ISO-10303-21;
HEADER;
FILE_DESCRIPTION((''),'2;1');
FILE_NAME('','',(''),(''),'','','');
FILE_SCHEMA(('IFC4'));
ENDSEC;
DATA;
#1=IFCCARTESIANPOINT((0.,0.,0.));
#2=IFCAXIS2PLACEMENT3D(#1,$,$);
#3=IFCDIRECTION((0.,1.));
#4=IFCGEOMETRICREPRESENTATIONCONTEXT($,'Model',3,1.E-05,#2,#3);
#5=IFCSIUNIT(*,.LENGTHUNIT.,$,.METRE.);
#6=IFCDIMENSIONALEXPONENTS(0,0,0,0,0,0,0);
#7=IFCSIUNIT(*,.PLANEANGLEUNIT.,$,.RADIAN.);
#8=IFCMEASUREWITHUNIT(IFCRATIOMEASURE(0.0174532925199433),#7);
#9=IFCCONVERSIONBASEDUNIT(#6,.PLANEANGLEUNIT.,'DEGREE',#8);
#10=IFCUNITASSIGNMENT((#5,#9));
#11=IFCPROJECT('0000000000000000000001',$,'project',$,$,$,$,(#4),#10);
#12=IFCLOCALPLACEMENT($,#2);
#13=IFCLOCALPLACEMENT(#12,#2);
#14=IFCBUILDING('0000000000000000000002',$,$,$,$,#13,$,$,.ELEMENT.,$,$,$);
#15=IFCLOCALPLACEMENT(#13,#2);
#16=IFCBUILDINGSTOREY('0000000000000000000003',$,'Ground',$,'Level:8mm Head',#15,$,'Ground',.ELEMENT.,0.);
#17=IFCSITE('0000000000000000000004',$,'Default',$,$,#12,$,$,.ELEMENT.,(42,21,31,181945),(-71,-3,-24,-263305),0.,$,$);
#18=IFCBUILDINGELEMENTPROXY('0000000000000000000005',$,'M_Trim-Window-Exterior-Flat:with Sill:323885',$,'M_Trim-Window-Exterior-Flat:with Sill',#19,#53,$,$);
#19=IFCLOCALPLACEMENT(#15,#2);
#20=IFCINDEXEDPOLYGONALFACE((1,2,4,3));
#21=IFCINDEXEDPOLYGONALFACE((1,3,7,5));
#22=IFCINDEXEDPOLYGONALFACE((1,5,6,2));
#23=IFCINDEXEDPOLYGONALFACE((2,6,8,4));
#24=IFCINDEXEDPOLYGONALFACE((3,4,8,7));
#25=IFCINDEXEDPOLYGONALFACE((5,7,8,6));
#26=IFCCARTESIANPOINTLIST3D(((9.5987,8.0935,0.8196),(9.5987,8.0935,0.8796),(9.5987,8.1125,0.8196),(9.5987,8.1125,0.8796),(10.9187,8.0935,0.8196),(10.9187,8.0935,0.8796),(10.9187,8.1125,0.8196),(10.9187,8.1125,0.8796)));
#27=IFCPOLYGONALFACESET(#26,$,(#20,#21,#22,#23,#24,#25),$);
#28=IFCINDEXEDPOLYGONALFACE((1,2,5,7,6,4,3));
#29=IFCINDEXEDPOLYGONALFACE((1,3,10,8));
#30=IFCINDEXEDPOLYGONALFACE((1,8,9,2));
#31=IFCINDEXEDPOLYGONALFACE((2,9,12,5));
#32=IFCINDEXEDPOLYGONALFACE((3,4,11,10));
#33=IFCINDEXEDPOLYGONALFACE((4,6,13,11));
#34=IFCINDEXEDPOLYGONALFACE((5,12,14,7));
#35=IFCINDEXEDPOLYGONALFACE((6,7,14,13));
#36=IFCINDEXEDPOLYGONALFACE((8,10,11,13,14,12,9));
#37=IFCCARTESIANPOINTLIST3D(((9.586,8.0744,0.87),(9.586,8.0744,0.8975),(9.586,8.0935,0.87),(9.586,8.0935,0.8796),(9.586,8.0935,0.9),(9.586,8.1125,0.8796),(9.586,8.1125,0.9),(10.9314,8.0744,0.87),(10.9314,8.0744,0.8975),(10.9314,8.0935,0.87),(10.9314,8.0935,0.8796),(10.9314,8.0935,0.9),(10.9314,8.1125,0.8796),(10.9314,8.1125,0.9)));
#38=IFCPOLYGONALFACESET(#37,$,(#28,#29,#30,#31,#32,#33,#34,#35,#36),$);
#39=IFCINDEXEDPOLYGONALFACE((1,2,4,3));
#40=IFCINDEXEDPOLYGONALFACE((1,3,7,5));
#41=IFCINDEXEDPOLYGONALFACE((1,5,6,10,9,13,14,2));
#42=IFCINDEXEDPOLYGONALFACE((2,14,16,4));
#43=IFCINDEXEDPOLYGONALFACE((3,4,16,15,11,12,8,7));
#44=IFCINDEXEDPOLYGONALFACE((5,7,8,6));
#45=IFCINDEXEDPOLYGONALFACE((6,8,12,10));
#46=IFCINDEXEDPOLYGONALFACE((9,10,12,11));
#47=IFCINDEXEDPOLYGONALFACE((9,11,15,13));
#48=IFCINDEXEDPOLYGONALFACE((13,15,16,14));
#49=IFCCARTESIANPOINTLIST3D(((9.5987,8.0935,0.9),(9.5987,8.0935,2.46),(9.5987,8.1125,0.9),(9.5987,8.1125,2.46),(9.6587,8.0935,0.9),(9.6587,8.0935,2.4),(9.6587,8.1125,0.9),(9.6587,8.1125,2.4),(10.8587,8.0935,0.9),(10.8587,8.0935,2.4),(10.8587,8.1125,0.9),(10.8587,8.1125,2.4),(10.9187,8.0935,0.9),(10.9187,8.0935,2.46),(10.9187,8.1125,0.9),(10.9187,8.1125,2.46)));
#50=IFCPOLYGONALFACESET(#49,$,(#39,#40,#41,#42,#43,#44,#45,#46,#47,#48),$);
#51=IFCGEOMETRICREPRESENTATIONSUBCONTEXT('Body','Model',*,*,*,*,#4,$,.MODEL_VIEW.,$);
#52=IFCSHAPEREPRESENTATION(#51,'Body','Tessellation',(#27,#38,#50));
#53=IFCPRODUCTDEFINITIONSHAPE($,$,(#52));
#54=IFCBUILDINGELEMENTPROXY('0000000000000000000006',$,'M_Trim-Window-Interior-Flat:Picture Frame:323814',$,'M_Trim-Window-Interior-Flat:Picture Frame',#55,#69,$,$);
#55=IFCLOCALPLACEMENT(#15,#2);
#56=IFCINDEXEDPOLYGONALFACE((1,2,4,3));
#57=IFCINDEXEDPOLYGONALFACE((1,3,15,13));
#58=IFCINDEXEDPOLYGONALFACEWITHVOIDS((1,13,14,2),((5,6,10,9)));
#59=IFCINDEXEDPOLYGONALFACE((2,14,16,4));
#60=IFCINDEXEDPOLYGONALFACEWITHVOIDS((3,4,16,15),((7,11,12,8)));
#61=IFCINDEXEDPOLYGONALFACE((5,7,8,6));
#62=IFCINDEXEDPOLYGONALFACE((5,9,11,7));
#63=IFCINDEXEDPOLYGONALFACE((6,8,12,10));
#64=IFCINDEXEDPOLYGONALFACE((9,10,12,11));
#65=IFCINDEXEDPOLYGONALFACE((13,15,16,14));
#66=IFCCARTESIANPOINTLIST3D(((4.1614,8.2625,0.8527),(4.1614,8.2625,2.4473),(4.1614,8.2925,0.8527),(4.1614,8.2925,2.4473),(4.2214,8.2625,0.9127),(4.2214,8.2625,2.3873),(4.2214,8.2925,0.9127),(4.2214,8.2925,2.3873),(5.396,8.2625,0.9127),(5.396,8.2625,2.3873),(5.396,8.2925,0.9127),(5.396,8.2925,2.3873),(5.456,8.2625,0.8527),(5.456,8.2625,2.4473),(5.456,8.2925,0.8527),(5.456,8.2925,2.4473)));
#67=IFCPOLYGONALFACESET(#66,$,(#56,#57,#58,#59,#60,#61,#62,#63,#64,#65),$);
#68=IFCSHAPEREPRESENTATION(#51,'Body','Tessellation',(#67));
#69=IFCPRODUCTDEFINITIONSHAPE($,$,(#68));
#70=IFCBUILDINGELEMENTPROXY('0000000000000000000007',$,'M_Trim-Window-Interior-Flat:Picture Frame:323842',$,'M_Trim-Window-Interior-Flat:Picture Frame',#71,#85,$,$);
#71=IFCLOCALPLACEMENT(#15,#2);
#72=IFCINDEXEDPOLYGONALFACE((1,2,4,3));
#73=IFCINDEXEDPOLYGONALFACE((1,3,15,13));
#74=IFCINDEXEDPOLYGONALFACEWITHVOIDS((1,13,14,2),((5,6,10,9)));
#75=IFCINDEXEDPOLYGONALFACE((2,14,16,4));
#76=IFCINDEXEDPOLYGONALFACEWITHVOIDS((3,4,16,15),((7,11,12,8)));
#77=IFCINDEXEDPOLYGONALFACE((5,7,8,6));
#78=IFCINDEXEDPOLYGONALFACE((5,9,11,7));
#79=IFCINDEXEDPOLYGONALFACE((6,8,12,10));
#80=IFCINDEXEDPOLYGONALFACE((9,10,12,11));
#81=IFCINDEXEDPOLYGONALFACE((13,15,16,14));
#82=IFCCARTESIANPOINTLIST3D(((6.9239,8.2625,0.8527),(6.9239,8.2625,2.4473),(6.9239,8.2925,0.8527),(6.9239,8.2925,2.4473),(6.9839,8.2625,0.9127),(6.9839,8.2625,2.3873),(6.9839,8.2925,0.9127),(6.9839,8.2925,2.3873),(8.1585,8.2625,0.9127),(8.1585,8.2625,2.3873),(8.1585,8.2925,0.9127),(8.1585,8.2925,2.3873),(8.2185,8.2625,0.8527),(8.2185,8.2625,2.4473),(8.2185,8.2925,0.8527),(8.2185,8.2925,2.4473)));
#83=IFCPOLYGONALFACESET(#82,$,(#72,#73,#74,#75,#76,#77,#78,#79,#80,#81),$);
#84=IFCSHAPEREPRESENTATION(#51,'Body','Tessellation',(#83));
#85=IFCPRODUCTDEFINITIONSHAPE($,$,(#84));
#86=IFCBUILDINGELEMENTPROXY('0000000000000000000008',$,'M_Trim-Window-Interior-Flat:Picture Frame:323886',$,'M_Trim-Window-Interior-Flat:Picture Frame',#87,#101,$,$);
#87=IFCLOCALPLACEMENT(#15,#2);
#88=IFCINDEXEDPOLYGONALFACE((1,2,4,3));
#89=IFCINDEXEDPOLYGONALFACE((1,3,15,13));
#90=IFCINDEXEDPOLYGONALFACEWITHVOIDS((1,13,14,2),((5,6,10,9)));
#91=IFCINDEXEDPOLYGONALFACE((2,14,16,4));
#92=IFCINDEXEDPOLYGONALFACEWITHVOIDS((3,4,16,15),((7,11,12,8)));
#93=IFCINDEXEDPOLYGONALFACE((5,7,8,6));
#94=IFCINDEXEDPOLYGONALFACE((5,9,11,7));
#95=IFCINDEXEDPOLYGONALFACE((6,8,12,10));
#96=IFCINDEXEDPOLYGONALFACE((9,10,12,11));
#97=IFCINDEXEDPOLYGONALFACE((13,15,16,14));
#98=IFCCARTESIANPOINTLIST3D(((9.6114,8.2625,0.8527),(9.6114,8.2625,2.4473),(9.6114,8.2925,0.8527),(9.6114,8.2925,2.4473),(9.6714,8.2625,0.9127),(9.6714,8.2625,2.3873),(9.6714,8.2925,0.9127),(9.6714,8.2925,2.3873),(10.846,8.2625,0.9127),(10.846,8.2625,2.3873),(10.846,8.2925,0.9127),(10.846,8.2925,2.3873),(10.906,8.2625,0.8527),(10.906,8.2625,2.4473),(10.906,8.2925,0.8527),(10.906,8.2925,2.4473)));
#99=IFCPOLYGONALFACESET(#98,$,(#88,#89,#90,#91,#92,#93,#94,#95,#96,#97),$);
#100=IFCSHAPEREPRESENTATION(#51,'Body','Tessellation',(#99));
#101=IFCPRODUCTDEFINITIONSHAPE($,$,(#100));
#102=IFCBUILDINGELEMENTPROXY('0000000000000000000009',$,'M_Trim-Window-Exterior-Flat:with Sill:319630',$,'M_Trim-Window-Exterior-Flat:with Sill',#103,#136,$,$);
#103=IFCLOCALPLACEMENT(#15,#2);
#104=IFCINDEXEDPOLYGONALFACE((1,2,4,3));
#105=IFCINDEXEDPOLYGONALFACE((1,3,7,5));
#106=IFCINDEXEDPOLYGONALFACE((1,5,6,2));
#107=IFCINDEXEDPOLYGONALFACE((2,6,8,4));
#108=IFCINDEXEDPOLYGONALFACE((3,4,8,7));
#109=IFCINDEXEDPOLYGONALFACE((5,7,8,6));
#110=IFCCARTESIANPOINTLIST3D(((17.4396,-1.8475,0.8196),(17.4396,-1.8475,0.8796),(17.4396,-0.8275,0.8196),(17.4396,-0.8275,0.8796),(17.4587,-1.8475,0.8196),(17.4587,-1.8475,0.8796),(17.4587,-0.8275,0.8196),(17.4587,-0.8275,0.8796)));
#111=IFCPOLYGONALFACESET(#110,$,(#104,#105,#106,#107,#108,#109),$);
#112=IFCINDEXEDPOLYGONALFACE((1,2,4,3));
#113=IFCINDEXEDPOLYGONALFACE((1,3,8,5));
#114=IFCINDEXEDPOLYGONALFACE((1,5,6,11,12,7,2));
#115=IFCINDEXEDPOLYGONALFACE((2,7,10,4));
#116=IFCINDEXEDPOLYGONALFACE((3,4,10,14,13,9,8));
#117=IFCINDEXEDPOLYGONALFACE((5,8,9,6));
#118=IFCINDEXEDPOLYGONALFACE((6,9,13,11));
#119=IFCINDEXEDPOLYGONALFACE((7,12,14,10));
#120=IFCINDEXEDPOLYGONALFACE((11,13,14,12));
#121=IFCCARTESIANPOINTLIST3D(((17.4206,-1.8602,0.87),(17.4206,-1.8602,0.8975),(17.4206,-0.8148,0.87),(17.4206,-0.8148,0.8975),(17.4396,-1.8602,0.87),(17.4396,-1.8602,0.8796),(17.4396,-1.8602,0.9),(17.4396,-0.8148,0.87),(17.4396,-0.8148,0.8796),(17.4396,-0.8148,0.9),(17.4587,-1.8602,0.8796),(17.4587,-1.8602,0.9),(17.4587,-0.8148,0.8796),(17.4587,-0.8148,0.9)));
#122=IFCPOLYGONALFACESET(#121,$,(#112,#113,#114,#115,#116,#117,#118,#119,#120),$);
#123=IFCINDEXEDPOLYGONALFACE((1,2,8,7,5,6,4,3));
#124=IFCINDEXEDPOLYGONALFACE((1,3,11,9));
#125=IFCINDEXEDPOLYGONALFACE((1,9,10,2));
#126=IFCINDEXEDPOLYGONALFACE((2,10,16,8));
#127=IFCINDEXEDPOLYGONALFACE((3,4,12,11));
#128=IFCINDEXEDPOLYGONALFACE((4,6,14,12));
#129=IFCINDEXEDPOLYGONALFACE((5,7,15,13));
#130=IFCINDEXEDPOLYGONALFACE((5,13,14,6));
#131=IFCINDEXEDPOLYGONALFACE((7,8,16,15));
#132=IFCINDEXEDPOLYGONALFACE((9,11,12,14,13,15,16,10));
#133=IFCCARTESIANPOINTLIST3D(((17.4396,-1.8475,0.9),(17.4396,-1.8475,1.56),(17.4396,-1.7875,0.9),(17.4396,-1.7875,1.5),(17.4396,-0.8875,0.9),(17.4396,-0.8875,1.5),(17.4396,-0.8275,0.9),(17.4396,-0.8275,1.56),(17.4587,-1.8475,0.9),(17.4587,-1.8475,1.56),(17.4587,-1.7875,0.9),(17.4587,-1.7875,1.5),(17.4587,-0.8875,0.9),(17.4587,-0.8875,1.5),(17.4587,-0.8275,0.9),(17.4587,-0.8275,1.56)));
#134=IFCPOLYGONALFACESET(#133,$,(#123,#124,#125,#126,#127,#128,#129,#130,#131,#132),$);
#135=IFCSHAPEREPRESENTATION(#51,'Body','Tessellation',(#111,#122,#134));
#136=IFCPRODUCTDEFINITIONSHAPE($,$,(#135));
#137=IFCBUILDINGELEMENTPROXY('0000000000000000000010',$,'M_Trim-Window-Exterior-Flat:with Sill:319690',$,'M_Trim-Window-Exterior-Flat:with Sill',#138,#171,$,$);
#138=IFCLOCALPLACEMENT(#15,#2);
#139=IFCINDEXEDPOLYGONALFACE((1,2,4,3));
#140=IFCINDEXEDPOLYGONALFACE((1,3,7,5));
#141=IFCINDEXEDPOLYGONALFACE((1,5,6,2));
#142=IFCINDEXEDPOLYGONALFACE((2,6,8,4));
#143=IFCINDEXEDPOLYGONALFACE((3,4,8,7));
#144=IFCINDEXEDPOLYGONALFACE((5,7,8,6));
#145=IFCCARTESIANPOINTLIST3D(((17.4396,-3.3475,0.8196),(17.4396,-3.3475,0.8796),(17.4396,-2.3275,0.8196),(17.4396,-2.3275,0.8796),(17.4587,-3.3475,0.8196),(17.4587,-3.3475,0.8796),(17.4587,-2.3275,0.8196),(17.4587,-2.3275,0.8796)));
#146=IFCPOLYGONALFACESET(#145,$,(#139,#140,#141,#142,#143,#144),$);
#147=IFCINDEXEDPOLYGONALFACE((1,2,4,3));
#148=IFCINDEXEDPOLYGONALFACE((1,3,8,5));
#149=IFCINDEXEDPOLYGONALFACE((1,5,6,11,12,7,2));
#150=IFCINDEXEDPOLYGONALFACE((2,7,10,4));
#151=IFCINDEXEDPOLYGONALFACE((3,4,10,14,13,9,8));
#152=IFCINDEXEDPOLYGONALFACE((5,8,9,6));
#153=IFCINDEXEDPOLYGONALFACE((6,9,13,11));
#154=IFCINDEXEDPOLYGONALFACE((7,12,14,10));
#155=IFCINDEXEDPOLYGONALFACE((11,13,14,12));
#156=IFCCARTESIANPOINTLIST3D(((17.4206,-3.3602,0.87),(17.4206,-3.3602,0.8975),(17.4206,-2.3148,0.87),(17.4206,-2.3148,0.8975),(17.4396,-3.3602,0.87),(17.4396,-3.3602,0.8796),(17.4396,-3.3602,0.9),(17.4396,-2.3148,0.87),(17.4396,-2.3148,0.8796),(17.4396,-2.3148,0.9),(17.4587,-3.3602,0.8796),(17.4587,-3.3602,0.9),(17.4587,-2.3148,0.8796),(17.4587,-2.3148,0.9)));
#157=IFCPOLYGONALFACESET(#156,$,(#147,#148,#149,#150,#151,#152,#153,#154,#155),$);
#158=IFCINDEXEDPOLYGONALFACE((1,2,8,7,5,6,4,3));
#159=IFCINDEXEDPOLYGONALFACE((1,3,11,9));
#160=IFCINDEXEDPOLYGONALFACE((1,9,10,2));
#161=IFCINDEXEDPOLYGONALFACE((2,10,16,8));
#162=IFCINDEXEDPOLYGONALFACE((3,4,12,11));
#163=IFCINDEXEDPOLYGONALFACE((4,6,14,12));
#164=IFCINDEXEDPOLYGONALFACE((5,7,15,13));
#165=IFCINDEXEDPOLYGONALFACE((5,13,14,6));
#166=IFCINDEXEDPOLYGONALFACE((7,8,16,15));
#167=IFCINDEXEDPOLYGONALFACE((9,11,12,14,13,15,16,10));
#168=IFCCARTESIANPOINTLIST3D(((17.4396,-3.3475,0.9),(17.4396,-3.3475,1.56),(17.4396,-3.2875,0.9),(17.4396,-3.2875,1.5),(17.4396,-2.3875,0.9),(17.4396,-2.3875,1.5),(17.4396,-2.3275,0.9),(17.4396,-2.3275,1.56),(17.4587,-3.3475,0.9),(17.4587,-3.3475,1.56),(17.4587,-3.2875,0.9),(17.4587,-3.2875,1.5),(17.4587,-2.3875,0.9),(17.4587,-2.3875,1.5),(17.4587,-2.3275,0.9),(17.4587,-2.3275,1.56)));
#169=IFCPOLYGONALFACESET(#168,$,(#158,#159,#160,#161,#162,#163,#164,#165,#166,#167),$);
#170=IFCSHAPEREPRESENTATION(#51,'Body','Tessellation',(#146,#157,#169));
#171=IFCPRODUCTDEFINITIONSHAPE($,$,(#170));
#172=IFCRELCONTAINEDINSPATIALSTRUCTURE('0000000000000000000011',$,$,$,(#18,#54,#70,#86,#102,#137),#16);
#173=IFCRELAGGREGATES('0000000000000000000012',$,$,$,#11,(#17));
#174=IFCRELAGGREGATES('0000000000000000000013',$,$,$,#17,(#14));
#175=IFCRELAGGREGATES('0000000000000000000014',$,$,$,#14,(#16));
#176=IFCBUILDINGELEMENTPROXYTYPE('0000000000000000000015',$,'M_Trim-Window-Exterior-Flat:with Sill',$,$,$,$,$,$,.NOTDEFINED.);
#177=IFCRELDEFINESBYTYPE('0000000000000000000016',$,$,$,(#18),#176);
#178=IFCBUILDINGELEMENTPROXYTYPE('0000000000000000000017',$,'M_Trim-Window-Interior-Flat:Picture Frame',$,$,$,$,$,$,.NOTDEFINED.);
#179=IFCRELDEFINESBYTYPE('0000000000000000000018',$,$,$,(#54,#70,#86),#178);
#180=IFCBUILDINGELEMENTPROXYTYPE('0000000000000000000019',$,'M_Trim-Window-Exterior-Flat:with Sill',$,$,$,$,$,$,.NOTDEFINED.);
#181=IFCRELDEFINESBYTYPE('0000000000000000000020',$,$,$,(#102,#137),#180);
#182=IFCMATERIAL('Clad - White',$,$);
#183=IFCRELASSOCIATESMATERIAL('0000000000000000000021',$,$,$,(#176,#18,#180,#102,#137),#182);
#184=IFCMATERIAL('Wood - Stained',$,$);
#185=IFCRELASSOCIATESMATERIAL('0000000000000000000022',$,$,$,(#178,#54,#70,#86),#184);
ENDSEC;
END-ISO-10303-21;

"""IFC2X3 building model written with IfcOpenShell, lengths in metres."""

from ifc_helpers import new_model, entity, si_unit, converted_unit, direction, frame, frame_2d, origin, place, context, subcontext, project, spatial, polyline, rectangle, outline, extrude, source, transform, mapped, material, type_object, type_shapes, element, save


model = new_model("IFC2X3")

# Units and contexts
model_context = context("Model", 3, precision=1e-05, world=origin(), true_north=direction((0.0, 1.0)))
body_context = subcontext(model_context, "Body", "Model", "MODEL_VIEW")
ifc_project = project(units=[si_unit("LENGTHUNIT", "METRE"), converted_unit("PLANEANGLEUNIT", "DEGREE", entity("IfcRatioMeasure", 0.0174532925199433), si_unit("PLANEANGLEUNIT", "RADIAN"), dimensions=[0, 0, 0, 0, 0, 0, 0])], contexts=[model_context])

# Site, building, storey
site_placement = place(None, origin())
site = spatial("IfcSite", under=ifc_project, at=site_placement, Name="Default", CompositionType="ELEMENT", RefLatitude=(42, 21, 31, 181945), RefLongitude=(-71, -3, -24, -263305), RefElevation=0.0)
building_placement = place(site_placement, origin())
building = spatial("IfcBuilding", under=site, at=building_placement, CompositionType="ELEMENT")
storey_placement = place(building_placement, origin())
storey = spatial("IfcBuildingStorey", under=building, at=storey_placement, Name="Ground", ObjectType="Level:8mm Head", LongName="Ground", CompositionType="ELEMENT", Elevation=0.0)

# Building element proxies
ifc_material_1 = material(Name="Clad - White")
ifc_material_2 = material(Name="Wood - Stained")
building_element_proxy_type_1 = type_object("IfcBuildingElementProxyType", Name="M_Trim-Window-Exterior-Flat:with Sill", PredefinedType="NOTDEFINED", material=ifc_material_1)
shared_shape_1 = source(origin(), body_context, "Body", "SweptSolid", [
    extrude(rectangle(XDim=1.32, YDim=0.06, at=frame_2d((0.0, 0.0), x_axis=(1.0, 0.0))), frame((0.0, -1.5504, 0.0), z_axis=(0.0, 0.0, 1.0), x_axis=(-1.0, 0.0, 0.0)), (0.0, 0.0, 1.0), 0.0191),
    extrude(outline(polyline([(-0.019, -0.0152), (0.0, -0.0152), (0.0, -0.0057), (0.019, -0.0057), (0.019, 0.0148), (0.0, 0.0148), (-0.019, 0.0123), (-0.019, -0.0152)])), frame((-0.6727, -1.5148, 0.019), z_axis=(1.0, 0.0, 0.0), x_axis=(0.0, 0.0, -1.0)), (0.0, 0.0, 1.0), 1.3454),
    extrude(outline(polyline([(-0.795, -0.66), (0.765, -0.66), (0.765, -0.6), (-0.735, -0.6), (-0.735, 0.6), (0.765, 0.6), (0.765, 0.66), (-0.795, 0.66), (-0.795, -0.66)])), frame((0.0, -0.735, 0.0), z_axis=(0.0, 0.0, 1.0), x_axis=(0.0, -1.0, 0.0)), (0.0, 0.0, 1.0), 0.0191),
])
type_shapes(building_element_proxy_type_1, [shared_shape_1])
for number, where, z_axis, x_axis, name in (
    (1, (10.2587, 8.1125, 2.4), (0.0, -1.0, 0.0), (1.0, 0.0, 0.0), "M_Trim-Window-Exterior-Flat:with Sill:323885"),
):
    element("IfcBuildingElementProxy", number, at=place(storey_placement, frame(where, z_axis=z_axis, x_axis=x_axis)), inside=storey, type_object=building_element_proxy_type_1, material=ifc_material_1, Name=name, ObjectType="M_Trim-Window-Exterior-Flat:with Sill", context=body_context, shape_type="MappedRepresentation", body=[
        mapped(shared_shape_1, transform((0.0, 0.0, 0.0), scale=1.0)),
    ])
building_element_proxy_type_2 = type_object("IfcBuildingElementProxyType", Name="M_Trim-Window-Interior-Flat:Picture Frame", PredefinedType="NOTDEFINED", material=ifc_material_2)
shared_shape_2 = source(origin(), body_context, "Body", "SweptSolid", [
    extrude(outline(polyline([(-0.6473, -0.7973), (0.6473, -0.7973), (0.6473, 0.7973), (-0.6473, 0.7973), (-0.6473, -0.7973)]), holes=[polyline([(-0.5873, -0.7373), (-0.5873, 0.7373), (0.5873, 0.7373), (0.5873, -0.7373), (-0.5873, -0.7373)])]), frame((0.0, -0.75, 0.0), z_axis=(0.0, 0.0, 1.0), x_axis=(-1.0, 0.0, 0.0)), (0.0, 0.0, 1.0), 0.03),
])
type_shapes(building_element_proxy_type_2, [shared_shape_2])
for number, where, z_axis, x_axis, name in (
    (2, (4.8087, 8.2625, 2.4), (0.0, 1.0, 0.0), (-1.0, 0.0, 0.0), "M_Trim-Window-Interior-Flat:Picture Frame:323814"),
    (3, (7.5712, 8.2625, 2.4), (0.0, 1.0, 0.0), (-1.0, 0.0, 0.0), "M_Trim-Window-Interior-Flat:Picture Frame:323842"),
    (4, (10.2587, 8.2625, 2.4), (0.0, 1.0, 0.0), (-1.0, 0.0, 0.0), "M_Trim-Window-Interior-Flat:Picture Frame:323886"),
):
    element("IfcBuildingElementProxy", number, at=place(storey_placement, frame(where, z_axis=z_axis, x_axis=x_axis)), inside=storey, type_object=building_element_proxy_type_2, material=ifc_material_2, Name=name, ObjectType="M_Trim-Window-Interior-Flat:Picture Frame", context=body_context, shape_type="MappedRepresentation", body=[
        mapped(shared_shape_2, transform((0.0, 0.0, 0.0), scale=1.0)),
    ])
building_element_proxy_type_3 = type_object("IfcBuildingElementProxyType", Name="M_Trim-Window-Exterior-Flat:with Sill", PredefinedType="NOTDEFINED", material=ifc_material_1)
shared_shape_3 = source(origin(), body_context, "Body", "SweptSolid", [
    extrude(rectangle(XDim=1.02, YDim=0.06, at=frame_2d((0.0, 0.0), x_axis=(1.0, 0.0))), frame((0.0, -0.6504, 0.0), z_axis=(0.0, 0.0, 1.0), x_axis=(-1.0, 0.0, 0.0)), (0.0, 0.0, 1.0), 0.0191),
    extrude(outline(polyline([(-0.019, -0.0152), (0.0, -0.0152), (0.0, -0.0057), (0.019, -0.0057), (0.019, 0.0148), (0.0, 0.0148), (-0.019, 0.0123), (-0.019, -0.0152)])), frame((-0.5227, -0.6148, 0.019), z_axis=(1.0, 0.0, 0.0), x_axis=(0.0, 0.0, -1.0)), (0.0, 0.0, 1.0), 1.0454),
    extrude(outline(polyline([(-0.345, -0.51), (0.315, -0.51), (0.315, -0.45), (-0.285, -0.45), (-0.285, 0.45), (0.315, 0.45), (0.315, 0.51), (-0.345, 0.51), (-0.345, -0.51)])), frame((0.0, -0.285, 0.0), z_axis=(0.0, 0.0, 1.0), x_axis=(0.0, -1.0, 0.0)), (0.0, 0.0, 1.0), 0.0191),
])
type_shapes(building_element_proxy_type_3, [shared_shape_3])
for number, where, z_axis, x_axis, name in (
    (5, (17.4587, -1.3375, 1.5), (-1.0, 0.0, 0.0), (0.0, -1.0, 0.0), "M_Trim-Window-Exterior-Flat:with Sill:319630"),
    (6, (17.4587, -2.8375, 1.5), (-1.0, 0.0, 0.0), (0.0, -1.0, 0.0), "M_Trim-Window-Exterior-Flat:with Sill:319690"),
):
    element("IfcBuildingElementProxy", number, at=place(storey_placement, frame(where, z_axis=z_axis, x_axis=x_axis)), inside=storey, type_object=building_element_proxy_type_3, material=ifc_material_1, Name=name, ObjectType="M_Trim-Window-Exterior-Flat:with Sill", context=body_context, shape_type="MappedRepresentation", body=[
        mapped(shared_shape_3, transform((0.0, 0.0, 0.0), scale=1.0)),
    ])

save(model, "model.ifc")
